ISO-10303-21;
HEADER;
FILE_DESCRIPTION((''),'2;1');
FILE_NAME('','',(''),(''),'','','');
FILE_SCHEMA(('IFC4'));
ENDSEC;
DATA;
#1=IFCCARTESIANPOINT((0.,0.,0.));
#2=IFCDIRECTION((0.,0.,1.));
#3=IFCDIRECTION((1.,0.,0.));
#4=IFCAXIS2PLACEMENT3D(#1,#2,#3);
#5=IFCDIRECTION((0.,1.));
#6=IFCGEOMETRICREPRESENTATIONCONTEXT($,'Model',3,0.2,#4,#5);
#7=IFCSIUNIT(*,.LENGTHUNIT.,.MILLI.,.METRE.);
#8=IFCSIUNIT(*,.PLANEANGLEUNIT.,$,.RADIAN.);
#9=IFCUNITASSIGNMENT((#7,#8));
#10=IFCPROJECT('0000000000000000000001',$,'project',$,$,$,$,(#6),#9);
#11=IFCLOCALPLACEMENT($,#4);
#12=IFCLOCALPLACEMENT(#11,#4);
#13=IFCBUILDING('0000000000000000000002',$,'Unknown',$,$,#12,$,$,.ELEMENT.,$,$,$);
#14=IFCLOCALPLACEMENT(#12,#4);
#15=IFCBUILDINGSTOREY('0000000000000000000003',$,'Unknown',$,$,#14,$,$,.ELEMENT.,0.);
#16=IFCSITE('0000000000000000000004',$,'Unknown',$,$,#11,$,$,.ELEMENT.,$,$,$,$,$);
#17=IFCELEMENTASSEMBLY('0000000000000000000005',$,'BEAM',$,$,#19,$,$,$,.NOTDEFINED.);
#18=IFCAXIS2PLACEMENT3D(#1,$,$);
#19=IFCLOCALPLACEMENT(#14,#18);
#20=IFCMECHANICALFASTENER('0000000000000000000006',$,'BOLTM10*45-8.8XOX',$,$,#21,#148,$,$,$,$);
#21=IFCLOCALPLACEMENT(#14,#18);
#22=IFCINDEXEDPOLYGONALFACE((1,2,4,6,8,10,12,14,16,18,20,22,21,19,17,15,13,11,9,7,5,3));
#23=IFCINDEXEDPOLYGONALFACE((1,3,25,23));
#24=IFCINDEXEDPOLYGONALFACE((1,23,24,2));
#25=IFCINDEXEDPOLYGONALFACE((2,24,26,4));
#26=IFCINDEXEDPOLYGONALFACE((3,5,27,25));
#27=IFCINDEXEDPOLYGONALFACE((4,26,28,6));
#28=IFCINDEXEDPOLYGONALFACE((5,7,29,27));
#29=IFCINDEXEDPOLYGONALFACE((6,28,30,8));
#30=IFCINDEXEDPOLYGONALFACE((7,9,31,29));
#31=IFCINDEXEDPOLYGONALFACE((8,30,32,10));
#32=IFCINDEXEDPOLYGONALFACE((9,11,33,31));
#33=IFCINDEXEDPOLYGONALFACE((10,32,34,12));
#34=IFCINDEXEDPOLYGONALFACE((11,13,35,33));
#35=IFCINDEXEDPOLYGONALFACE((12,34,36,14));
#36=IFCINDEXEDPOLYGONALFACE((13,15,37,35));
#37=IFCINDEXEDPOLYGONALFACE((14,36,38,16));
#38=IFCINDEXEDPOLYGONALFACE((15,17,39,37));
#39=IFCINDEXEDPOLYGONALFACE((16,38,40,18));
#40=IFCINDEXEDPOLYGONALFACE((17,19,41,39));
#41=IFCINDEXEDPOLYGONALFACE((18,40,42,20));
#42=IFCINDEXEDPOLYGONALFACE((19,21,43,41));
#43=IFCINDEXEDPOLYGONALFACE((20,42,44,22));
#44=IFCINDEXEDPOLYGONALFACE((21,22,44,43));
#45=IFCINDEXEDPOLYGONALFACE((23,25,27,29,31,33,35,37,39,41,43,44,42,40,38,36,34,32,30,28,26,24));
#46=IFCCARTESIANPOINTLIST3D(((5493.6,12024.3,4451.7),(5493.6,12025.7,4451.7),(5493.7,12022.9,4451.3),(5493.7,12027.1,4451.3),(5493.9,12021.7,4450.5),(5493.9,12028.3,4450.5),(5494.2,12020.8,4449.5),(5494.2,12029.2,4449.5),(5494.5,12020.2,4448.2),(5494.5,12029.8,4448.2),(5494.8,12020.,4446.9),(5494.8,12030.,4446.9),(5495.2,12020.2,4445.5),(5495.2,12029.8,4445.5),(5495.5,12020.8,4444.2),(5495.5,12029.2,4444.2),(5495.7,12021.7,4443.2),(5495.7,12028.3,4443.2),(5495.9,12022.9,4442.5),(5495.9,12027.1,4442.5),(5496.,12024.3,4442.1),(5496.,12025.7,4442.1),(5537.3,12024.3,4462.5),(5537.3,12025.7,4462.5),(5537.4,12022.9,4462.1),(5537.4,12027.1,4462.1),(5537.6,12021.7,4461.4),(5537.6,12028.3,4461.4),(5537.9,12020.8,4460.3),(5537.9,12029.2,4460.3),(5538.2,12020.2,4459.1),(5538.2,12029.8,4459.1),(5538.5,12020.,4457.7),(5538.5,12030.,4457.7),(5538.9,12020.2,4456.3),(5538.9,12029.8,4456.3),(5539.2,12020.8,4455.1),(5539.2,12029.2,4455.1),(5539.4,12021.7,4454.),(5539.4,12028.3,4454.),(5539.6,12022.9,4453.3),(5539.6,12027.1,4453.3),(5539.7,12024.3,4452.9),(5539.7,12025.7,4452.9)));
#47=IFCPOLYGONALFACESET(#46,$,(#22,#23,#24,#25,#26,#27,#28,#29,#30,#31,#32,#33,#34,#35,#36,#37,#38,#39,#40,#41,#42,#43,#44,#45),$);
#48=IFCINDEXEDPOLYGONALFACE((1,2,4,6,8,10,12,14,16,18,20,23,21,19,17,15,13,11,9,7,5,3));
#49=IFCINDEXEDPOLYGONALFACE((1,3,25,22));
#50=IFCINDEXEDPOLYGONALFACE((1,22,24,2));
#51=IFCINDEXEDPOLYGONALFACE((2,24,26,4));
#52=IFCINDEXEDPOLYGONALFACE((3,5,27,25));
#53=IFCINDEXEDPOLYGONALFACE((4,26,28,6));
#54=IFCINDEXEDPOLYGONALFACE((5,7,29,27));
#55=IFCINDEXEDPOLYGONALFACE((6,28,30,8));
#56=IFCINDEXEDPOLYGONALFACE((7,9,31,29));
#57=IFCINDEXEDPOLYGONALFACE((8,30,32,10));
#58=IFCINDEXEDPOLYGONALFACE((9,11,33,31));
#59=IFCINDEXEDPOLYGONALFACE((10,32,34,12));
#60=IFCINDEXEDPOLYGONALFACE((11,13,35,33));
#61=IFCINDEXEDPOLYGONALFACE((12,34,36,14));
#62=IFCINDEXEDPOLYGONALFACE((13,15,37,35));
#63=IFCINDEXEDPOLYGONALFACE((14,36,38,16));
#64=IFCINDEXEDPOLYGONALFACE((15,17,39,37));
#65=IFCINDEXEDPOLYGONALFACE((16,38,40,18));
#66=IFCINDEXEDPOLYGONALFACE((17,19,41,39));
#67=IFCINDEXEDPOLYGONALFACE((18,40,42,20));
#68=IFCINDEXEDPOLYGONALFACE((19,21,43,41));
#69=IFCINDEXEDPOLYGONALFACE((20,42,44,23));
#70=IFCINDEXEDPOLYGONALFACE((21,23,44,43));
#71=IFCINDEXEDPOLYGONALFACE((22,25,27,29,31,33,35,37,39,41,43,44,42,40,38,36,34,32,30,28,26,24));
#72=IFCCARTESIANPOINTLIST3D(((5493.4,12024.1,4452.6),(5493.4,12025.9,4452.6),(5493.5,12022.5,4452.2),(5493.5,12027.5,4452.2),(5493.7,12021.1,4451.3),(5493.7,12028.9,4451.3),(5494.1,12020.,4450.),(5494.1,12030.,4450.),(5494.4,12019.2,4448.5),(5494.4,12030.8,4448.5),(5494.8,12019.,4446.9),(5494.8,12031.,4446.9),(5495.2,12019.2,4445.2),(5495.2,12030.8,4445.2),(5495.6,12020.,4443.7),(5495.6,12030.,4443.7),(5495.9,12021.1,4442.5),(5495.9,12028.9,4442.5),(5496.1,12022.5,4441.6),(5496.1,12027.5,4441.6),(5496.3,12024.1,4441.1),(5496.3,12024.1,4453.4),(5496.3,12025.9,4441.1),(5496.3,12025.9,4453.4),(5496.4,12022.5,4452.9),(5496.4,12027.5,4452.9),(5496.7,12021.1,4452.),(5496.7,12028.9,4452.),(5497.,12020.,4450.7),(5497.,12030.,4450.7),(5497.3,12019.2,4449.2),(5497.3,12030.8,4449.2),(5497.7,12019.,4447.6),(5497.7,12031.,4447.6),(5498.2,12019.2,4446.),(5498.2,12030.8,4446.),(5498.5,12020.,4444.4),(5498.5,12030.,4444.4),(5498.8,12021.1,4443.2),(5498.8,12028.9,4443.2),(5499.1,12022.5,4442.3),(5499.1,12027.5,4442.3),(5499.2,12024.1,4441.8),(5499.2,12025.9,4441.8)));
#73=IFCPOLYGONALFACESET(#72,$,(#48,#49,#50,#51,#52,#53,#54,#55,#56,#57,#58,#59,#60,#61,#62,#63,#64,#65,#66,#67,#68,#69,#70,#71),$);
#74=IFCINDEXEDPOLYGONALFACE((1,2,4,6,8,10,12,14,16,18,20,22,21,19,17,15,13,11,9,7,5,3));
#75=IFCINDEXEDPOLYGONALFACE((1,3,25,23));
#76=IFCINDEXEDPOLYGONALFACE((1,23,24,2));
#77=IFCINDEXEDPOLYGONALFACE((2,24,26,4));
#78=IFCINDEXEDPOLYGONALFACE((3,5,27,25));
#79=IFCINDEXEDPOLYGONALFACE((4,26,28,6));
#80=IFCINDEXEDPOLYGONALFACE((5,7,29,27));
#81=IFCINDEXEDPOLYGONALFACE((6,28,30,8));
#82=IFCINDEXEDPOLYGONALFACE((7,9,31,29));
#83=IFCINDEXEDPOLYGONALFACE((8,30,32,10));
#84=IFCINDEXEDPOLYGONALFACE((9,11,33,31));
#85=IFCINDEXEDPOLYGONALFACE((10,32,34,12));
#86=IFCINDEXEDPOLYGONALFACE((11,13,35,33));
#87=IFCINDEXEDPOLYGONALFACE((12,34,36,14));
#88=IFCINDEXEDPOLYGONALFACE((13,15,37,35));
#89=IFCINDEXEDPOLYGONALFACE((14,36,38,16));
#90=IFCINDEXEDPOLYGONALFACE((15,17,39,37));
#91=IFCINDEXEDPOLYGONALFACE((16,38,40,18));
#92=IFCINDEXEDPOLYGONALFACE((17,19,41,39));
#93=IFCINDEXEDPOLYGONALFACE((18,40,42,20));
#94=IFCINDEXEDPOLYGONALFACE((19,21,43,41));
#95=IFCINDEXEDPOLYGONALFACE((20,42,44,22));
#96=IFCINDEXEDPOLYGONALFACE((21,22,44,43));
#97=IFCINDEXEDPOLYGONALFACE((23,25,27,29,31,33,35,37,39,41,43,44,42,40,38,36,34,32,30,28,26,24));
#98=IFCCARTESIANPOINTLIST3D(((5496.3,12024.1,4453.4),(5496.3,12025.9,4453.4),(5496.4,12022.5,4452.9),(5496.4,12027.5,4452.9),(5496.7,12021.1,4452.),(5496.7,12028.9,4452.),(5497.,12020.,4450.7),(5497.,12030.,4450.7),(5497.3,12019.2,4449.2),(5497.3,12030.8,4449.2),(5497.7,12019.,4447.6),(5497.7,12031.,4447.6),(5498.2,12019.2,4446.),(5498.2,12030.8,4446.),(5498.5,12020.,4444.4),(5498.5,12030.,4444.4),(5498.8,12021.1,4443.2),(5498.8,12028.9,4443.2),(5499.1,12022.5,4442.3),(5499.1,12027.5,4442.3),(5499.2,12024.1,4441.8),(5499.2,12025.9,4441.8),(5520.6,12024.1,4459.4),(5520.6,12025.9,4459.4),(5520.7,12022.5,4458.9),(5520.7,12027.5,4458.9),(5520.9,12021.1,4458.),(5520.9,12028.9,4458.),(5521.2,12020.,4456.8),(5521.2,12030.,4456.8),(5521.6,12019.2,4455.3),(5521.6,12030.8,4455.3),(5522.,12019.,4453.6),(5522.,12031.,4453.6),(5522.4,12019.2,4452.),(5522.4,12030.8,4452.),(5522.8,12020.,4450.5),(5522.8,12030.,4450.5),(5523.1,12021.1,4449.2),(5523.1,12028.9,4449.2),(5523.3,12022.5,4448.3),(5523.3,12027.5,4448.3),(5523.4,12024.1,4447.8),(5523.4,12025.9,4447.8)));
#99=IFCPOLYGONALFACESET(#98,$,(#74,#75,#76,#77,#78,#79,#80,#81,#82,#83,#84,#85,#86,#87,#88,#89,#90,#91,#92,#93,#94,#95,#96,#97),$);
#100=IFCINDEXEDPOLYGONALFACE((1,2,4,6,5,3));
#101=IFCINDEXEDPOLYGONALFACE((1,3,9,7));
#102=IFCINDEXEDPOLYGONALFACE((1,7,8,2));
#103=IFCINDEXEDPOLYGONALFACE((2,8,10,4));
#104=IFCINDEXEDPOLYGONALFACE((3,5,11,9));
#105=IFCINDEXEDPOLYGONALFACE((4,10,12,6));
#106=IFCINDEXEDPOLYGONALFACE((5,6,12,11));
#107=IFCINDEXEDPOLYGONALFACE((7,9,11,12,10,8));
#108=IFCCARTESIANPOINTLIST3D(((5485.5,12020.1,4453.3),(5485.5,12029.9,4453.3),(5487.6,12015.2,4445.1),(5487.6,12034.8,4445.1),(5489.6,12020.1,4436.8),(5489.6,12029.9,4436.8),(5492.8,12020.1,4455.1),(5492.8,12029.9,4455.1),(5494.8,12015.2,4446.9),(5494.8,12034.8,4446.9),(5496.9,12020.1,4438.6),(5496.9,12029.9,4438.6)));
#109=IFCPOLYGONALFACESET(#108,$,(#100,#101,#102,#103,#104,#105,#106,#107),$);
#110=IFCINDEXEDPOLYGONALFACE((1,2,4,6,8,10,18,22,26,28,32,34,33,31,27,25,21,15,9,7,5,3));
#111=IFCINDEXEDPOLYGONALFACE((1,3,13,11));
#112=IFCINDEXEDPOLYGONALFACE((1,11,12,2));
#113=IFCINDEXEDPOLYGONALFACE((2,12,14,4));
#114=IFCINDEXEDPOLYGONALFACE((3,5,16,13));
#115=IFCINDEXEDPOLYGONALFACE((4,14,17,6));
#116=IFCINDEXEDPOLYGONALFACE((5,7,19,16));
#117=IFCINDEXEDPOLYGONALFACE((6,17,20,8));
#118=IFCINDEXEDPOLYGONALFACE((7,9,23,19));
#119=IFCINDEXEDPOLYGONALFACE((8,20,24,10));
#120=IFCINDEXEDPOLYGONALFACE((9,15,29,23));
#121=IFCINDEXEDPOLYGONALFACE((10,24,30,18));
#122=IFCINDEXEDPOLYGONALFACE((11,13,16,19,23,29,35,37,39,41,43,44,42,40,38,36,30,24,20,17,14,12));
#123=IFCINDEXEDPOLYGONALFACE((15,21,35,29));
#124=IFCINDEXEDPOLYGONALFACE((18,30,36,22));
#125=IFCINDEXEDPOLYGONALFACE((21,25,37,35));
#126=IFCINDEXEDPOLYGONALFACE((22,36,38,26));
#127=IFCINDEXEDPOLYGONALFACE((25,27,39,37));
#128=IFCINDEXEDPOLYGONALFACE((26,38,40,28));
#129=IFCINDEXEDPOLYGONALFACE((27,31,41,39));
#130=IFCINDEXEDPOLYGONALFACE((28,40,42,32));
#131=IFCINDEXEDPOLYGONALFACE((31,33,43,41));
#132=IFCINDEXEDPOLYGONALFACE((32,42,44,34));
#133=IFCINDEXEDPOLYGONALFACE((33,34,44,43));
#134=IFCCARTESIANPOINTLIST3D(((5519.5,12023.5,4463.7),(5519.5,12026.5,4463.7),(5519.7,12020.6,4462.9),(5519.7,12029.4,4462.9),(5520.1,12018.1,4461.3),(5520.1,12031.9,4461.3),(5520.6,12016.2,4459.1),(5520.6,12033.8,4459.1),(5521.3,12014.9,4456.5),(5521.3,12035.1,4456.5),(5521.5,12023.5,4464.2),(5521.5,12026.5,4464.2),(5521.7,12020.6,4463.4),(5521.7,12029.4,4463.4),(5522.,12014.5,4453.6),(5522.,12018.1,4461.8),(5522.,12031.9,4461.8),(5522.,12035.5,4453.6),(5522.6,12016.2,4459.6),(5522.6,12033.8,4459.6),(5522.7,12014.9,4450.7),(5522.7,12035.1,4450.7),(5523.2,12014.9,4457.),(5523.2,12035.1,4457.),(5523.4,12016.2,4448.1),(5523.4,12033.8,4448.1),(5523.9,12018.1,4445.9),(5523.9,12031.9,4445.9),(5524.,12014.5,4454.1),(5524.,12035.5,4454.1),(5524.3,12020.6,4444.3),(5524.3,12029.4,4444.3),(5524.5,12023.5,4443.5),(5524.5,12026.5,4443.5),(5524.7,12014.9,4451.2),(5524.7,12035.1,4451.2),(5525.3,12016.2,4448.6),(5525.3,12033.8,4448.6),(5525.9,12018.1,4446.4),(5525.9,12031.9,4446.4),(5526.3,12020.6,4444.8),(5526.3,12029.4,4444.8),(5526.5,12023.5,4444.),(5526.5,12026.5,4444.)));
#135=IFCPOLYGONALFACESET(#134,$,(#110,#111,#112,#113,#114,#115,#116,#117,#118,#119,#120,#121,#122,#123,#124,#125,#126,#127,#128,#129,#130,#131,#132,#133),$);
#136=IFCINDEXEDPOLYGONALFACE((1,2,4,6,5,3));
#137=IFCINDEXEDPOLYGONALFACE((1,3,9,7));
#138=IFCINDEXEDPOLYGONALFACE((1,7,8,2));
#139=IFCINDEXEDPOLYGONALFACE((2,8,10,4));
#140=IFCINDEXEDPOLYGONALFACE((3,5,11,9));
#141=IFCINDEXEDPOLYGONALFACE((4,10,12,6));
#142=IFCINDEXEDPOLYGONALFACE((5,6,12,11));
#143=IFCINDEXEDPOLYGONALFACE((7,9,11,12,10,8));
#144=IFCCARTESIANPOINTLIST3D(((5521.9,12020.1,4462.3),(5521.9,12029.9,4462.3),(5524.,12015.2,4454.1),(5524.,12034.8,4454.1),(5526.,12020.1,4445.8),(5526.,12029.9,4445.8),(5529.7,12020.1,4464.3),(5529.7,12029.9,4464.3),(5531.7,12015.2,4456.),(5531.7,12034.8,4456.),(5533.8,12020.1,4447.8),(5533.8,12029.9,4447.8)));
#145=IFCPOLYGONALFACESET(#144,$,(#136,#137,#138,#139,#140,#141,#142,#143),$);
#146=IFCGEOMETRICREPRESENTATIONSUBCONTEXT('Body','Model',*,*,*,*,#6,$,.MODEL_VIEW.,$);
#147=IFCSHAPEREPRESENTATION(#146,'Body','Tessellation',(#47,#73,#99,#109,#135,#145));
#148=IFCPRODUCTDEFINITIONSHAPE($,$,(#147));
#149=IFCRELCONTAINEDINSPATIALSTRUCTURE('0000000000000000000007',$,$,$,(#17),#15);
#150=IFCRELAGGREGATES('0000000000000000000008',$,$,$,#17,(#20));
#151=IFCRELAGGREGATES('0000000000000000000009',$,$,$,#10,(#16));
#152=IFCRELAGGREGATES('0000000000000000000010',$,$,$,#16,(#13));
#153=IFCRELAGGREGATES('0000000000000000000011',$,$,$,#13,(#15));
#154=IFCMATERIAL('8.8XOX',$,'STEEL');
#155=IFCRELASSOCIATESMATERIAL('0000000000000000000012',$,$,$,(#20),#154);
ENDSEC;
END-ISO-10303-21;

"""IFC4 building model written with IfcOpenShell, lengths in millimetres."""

from ifc_helpers import new_model, si_unit, direction, frame, origin_with_axes, place, context, subcontext, project, spatial, line, arc, indexed_curve, outline, extrude, source, transform, mapped, material, element, aggregate, save


model = new_model("IFC4")

# Units and contexts
model_context = context("Model", 3, precision=0.2, world=origin_with_axes(), true_north=direction((0.0, 1.0)))
body_context = subcontext(model_context, "Body", "Model", "MODEL_VIEW")
ifc_project = project(units=[si_unit("LENGTHUNIT", "METRE", prefix="MILLI"), si_unit("PLANEANGLEUNIT", "RADIAN")], contexts=[model_context])

# Site, building, storey
site_placement = place(None, origin_with_axes())
site = spatial("IfcSite", under=ifc_project, at=site_placement, Name="Unknown", CompositionType="ELEMENT")
building_placement = place(site_placement, origin_with_axes())
building = spatial("IfcBuilding", under=site, at=building_placement, Name="Unknown", CompositionType="ELEMENT")
storey_placement = place(building_placement, origin_with_axes())
storey = spatial("IfcBuildingStorey", under=building, at=storey_placement, Name="Unknown", CompositionType="ELEMENT", Elevation=0.0)

# Shared definitions
ifc_material_1 = material(Name="8.8XOX", Category="STEEL")

# Element assembly, mechanical fastener
shared_shape_1 = source(origin_with_axes(), body_context, "Body", "SweptSolid", [
    extrude(outline(indexed_curve([(5.0, 0.0), (0.0, 5.0), (-5.0, 0.0), (0.0, -5.0)], segments=[arc(1, 2, 3), arc(3, 4, 1)])), frame((0.0, 0.0, 3.8), z_axis=(0.0, 0.0, -1.0), x_axis=(0.0, 1.0, 0.0)), (0.0, 0.0, 1.0), 45.0),
    extrude(outline(indexed_curve([(6.0, 0.0), (0.0, 6.0), (-6.0, 0.0), (0.0, -6.0)], segments=[arc(1, 2, 3), arc(3, 4, 1)])), frame((0.0, 0.0, 3.8), z_axis=(0.0, 0.0, -1.0), x_axis=(0.0, 1.0, 0.0)), (0.0, 0.0, 1.0), 3.0),
    extrude(outline(indexed_curve([(6.0, 0.0), (0.0, 6.0), (-6.0, 0.0), (0.0, -6.0)], segments=[arc(1, 2, 3), arc(3, 4, 1)])), frame((0.0, 0.0, 0.8), z_axis=(0.0, 0.0, -1.0), x_axis=(0.0, 1.0, 0.0)), (0.0, 0.0, 1.0), 25.0),
    extrude(outline(indexed_curve([(9.8, 0.0), (4.9, 8.5), (-4.9, 8.5), (-9.8, 0.0), (-4.9, -8.5), (4.9, -8.5)], segments=[line(1, 2, 3, 4, 5, 6, 1)])), frame((0.0, 0.0, 11.2), z_axis=(0.0, 0.0, -1.0), x_axis=(0.0, 1.0, 0.0)), (0.0, 0.0, 1.0), 7.5),
    extrude(outline(indexed_curve([(10.5, 0.0), (0.0, 10.5), (-10.5, 0.0), (0.0, -10.5)], segments=[arc(1, 2, 3), arc(3, 4, 1)])), frame((0.0, 0.0, -24.2), z_axis=(0.0, 0.0, -1.0), x_axis=(0.0, 1.0, 0.0)), (0.0, 0.0, 1.0), 2.0),
    extrude(outline(indexed_curve([(9.8, 0.0), (4.9, 8.5), (-4.9, 8.5), (-9.8, 0.0), (-4.9, -8.5), (4.9, -8.5)], segments=[line(1, 2, 3, 4, 5, 6, 1)])), frame((0.0, 0.0, -26.2), z_axis=(0.0, 0.0, -1.0), x_axis=(0.0, 1.0, 0.0)), (0.0, 0.0, 1.0), 8.0),
])
assembly_1_placement = place(storey_placement, frame((5508.7, 12000.0, 4455.5), z_axis=(0.970613, 0.0, 0.240648), x_axis=(0.0, 1.0, 0.0)))
assembly_1 = element("IfcElementAssembly", 1, at=assembly_1_placement, inside=storey, Name="BEAM", PredefinedType="NOTDEFINED")
mechanical_fastener_1_placement = place(assembly_1_placement, frame((25.0, -5.0, -11.8), z_axis=(0.0, 0.0, -1.0), x_axis=(0.0, 1.0, 0.0)))
mechanical_fastener_1 = element("IfcMechanicalFastener", 2, at=mechanical_fastener_1_placement, material=ifc_material_1, Name="BOLTM10*45-8.8XOX", context=body_context, shape_type="MappedRepresentation", body=[
    mapped(shared_shape_1, transform((0.0, 0.0, 0.0))),
])
aggregate(assembly_1, [mechanical_fastener_1])

save(model, "model.ifc")
